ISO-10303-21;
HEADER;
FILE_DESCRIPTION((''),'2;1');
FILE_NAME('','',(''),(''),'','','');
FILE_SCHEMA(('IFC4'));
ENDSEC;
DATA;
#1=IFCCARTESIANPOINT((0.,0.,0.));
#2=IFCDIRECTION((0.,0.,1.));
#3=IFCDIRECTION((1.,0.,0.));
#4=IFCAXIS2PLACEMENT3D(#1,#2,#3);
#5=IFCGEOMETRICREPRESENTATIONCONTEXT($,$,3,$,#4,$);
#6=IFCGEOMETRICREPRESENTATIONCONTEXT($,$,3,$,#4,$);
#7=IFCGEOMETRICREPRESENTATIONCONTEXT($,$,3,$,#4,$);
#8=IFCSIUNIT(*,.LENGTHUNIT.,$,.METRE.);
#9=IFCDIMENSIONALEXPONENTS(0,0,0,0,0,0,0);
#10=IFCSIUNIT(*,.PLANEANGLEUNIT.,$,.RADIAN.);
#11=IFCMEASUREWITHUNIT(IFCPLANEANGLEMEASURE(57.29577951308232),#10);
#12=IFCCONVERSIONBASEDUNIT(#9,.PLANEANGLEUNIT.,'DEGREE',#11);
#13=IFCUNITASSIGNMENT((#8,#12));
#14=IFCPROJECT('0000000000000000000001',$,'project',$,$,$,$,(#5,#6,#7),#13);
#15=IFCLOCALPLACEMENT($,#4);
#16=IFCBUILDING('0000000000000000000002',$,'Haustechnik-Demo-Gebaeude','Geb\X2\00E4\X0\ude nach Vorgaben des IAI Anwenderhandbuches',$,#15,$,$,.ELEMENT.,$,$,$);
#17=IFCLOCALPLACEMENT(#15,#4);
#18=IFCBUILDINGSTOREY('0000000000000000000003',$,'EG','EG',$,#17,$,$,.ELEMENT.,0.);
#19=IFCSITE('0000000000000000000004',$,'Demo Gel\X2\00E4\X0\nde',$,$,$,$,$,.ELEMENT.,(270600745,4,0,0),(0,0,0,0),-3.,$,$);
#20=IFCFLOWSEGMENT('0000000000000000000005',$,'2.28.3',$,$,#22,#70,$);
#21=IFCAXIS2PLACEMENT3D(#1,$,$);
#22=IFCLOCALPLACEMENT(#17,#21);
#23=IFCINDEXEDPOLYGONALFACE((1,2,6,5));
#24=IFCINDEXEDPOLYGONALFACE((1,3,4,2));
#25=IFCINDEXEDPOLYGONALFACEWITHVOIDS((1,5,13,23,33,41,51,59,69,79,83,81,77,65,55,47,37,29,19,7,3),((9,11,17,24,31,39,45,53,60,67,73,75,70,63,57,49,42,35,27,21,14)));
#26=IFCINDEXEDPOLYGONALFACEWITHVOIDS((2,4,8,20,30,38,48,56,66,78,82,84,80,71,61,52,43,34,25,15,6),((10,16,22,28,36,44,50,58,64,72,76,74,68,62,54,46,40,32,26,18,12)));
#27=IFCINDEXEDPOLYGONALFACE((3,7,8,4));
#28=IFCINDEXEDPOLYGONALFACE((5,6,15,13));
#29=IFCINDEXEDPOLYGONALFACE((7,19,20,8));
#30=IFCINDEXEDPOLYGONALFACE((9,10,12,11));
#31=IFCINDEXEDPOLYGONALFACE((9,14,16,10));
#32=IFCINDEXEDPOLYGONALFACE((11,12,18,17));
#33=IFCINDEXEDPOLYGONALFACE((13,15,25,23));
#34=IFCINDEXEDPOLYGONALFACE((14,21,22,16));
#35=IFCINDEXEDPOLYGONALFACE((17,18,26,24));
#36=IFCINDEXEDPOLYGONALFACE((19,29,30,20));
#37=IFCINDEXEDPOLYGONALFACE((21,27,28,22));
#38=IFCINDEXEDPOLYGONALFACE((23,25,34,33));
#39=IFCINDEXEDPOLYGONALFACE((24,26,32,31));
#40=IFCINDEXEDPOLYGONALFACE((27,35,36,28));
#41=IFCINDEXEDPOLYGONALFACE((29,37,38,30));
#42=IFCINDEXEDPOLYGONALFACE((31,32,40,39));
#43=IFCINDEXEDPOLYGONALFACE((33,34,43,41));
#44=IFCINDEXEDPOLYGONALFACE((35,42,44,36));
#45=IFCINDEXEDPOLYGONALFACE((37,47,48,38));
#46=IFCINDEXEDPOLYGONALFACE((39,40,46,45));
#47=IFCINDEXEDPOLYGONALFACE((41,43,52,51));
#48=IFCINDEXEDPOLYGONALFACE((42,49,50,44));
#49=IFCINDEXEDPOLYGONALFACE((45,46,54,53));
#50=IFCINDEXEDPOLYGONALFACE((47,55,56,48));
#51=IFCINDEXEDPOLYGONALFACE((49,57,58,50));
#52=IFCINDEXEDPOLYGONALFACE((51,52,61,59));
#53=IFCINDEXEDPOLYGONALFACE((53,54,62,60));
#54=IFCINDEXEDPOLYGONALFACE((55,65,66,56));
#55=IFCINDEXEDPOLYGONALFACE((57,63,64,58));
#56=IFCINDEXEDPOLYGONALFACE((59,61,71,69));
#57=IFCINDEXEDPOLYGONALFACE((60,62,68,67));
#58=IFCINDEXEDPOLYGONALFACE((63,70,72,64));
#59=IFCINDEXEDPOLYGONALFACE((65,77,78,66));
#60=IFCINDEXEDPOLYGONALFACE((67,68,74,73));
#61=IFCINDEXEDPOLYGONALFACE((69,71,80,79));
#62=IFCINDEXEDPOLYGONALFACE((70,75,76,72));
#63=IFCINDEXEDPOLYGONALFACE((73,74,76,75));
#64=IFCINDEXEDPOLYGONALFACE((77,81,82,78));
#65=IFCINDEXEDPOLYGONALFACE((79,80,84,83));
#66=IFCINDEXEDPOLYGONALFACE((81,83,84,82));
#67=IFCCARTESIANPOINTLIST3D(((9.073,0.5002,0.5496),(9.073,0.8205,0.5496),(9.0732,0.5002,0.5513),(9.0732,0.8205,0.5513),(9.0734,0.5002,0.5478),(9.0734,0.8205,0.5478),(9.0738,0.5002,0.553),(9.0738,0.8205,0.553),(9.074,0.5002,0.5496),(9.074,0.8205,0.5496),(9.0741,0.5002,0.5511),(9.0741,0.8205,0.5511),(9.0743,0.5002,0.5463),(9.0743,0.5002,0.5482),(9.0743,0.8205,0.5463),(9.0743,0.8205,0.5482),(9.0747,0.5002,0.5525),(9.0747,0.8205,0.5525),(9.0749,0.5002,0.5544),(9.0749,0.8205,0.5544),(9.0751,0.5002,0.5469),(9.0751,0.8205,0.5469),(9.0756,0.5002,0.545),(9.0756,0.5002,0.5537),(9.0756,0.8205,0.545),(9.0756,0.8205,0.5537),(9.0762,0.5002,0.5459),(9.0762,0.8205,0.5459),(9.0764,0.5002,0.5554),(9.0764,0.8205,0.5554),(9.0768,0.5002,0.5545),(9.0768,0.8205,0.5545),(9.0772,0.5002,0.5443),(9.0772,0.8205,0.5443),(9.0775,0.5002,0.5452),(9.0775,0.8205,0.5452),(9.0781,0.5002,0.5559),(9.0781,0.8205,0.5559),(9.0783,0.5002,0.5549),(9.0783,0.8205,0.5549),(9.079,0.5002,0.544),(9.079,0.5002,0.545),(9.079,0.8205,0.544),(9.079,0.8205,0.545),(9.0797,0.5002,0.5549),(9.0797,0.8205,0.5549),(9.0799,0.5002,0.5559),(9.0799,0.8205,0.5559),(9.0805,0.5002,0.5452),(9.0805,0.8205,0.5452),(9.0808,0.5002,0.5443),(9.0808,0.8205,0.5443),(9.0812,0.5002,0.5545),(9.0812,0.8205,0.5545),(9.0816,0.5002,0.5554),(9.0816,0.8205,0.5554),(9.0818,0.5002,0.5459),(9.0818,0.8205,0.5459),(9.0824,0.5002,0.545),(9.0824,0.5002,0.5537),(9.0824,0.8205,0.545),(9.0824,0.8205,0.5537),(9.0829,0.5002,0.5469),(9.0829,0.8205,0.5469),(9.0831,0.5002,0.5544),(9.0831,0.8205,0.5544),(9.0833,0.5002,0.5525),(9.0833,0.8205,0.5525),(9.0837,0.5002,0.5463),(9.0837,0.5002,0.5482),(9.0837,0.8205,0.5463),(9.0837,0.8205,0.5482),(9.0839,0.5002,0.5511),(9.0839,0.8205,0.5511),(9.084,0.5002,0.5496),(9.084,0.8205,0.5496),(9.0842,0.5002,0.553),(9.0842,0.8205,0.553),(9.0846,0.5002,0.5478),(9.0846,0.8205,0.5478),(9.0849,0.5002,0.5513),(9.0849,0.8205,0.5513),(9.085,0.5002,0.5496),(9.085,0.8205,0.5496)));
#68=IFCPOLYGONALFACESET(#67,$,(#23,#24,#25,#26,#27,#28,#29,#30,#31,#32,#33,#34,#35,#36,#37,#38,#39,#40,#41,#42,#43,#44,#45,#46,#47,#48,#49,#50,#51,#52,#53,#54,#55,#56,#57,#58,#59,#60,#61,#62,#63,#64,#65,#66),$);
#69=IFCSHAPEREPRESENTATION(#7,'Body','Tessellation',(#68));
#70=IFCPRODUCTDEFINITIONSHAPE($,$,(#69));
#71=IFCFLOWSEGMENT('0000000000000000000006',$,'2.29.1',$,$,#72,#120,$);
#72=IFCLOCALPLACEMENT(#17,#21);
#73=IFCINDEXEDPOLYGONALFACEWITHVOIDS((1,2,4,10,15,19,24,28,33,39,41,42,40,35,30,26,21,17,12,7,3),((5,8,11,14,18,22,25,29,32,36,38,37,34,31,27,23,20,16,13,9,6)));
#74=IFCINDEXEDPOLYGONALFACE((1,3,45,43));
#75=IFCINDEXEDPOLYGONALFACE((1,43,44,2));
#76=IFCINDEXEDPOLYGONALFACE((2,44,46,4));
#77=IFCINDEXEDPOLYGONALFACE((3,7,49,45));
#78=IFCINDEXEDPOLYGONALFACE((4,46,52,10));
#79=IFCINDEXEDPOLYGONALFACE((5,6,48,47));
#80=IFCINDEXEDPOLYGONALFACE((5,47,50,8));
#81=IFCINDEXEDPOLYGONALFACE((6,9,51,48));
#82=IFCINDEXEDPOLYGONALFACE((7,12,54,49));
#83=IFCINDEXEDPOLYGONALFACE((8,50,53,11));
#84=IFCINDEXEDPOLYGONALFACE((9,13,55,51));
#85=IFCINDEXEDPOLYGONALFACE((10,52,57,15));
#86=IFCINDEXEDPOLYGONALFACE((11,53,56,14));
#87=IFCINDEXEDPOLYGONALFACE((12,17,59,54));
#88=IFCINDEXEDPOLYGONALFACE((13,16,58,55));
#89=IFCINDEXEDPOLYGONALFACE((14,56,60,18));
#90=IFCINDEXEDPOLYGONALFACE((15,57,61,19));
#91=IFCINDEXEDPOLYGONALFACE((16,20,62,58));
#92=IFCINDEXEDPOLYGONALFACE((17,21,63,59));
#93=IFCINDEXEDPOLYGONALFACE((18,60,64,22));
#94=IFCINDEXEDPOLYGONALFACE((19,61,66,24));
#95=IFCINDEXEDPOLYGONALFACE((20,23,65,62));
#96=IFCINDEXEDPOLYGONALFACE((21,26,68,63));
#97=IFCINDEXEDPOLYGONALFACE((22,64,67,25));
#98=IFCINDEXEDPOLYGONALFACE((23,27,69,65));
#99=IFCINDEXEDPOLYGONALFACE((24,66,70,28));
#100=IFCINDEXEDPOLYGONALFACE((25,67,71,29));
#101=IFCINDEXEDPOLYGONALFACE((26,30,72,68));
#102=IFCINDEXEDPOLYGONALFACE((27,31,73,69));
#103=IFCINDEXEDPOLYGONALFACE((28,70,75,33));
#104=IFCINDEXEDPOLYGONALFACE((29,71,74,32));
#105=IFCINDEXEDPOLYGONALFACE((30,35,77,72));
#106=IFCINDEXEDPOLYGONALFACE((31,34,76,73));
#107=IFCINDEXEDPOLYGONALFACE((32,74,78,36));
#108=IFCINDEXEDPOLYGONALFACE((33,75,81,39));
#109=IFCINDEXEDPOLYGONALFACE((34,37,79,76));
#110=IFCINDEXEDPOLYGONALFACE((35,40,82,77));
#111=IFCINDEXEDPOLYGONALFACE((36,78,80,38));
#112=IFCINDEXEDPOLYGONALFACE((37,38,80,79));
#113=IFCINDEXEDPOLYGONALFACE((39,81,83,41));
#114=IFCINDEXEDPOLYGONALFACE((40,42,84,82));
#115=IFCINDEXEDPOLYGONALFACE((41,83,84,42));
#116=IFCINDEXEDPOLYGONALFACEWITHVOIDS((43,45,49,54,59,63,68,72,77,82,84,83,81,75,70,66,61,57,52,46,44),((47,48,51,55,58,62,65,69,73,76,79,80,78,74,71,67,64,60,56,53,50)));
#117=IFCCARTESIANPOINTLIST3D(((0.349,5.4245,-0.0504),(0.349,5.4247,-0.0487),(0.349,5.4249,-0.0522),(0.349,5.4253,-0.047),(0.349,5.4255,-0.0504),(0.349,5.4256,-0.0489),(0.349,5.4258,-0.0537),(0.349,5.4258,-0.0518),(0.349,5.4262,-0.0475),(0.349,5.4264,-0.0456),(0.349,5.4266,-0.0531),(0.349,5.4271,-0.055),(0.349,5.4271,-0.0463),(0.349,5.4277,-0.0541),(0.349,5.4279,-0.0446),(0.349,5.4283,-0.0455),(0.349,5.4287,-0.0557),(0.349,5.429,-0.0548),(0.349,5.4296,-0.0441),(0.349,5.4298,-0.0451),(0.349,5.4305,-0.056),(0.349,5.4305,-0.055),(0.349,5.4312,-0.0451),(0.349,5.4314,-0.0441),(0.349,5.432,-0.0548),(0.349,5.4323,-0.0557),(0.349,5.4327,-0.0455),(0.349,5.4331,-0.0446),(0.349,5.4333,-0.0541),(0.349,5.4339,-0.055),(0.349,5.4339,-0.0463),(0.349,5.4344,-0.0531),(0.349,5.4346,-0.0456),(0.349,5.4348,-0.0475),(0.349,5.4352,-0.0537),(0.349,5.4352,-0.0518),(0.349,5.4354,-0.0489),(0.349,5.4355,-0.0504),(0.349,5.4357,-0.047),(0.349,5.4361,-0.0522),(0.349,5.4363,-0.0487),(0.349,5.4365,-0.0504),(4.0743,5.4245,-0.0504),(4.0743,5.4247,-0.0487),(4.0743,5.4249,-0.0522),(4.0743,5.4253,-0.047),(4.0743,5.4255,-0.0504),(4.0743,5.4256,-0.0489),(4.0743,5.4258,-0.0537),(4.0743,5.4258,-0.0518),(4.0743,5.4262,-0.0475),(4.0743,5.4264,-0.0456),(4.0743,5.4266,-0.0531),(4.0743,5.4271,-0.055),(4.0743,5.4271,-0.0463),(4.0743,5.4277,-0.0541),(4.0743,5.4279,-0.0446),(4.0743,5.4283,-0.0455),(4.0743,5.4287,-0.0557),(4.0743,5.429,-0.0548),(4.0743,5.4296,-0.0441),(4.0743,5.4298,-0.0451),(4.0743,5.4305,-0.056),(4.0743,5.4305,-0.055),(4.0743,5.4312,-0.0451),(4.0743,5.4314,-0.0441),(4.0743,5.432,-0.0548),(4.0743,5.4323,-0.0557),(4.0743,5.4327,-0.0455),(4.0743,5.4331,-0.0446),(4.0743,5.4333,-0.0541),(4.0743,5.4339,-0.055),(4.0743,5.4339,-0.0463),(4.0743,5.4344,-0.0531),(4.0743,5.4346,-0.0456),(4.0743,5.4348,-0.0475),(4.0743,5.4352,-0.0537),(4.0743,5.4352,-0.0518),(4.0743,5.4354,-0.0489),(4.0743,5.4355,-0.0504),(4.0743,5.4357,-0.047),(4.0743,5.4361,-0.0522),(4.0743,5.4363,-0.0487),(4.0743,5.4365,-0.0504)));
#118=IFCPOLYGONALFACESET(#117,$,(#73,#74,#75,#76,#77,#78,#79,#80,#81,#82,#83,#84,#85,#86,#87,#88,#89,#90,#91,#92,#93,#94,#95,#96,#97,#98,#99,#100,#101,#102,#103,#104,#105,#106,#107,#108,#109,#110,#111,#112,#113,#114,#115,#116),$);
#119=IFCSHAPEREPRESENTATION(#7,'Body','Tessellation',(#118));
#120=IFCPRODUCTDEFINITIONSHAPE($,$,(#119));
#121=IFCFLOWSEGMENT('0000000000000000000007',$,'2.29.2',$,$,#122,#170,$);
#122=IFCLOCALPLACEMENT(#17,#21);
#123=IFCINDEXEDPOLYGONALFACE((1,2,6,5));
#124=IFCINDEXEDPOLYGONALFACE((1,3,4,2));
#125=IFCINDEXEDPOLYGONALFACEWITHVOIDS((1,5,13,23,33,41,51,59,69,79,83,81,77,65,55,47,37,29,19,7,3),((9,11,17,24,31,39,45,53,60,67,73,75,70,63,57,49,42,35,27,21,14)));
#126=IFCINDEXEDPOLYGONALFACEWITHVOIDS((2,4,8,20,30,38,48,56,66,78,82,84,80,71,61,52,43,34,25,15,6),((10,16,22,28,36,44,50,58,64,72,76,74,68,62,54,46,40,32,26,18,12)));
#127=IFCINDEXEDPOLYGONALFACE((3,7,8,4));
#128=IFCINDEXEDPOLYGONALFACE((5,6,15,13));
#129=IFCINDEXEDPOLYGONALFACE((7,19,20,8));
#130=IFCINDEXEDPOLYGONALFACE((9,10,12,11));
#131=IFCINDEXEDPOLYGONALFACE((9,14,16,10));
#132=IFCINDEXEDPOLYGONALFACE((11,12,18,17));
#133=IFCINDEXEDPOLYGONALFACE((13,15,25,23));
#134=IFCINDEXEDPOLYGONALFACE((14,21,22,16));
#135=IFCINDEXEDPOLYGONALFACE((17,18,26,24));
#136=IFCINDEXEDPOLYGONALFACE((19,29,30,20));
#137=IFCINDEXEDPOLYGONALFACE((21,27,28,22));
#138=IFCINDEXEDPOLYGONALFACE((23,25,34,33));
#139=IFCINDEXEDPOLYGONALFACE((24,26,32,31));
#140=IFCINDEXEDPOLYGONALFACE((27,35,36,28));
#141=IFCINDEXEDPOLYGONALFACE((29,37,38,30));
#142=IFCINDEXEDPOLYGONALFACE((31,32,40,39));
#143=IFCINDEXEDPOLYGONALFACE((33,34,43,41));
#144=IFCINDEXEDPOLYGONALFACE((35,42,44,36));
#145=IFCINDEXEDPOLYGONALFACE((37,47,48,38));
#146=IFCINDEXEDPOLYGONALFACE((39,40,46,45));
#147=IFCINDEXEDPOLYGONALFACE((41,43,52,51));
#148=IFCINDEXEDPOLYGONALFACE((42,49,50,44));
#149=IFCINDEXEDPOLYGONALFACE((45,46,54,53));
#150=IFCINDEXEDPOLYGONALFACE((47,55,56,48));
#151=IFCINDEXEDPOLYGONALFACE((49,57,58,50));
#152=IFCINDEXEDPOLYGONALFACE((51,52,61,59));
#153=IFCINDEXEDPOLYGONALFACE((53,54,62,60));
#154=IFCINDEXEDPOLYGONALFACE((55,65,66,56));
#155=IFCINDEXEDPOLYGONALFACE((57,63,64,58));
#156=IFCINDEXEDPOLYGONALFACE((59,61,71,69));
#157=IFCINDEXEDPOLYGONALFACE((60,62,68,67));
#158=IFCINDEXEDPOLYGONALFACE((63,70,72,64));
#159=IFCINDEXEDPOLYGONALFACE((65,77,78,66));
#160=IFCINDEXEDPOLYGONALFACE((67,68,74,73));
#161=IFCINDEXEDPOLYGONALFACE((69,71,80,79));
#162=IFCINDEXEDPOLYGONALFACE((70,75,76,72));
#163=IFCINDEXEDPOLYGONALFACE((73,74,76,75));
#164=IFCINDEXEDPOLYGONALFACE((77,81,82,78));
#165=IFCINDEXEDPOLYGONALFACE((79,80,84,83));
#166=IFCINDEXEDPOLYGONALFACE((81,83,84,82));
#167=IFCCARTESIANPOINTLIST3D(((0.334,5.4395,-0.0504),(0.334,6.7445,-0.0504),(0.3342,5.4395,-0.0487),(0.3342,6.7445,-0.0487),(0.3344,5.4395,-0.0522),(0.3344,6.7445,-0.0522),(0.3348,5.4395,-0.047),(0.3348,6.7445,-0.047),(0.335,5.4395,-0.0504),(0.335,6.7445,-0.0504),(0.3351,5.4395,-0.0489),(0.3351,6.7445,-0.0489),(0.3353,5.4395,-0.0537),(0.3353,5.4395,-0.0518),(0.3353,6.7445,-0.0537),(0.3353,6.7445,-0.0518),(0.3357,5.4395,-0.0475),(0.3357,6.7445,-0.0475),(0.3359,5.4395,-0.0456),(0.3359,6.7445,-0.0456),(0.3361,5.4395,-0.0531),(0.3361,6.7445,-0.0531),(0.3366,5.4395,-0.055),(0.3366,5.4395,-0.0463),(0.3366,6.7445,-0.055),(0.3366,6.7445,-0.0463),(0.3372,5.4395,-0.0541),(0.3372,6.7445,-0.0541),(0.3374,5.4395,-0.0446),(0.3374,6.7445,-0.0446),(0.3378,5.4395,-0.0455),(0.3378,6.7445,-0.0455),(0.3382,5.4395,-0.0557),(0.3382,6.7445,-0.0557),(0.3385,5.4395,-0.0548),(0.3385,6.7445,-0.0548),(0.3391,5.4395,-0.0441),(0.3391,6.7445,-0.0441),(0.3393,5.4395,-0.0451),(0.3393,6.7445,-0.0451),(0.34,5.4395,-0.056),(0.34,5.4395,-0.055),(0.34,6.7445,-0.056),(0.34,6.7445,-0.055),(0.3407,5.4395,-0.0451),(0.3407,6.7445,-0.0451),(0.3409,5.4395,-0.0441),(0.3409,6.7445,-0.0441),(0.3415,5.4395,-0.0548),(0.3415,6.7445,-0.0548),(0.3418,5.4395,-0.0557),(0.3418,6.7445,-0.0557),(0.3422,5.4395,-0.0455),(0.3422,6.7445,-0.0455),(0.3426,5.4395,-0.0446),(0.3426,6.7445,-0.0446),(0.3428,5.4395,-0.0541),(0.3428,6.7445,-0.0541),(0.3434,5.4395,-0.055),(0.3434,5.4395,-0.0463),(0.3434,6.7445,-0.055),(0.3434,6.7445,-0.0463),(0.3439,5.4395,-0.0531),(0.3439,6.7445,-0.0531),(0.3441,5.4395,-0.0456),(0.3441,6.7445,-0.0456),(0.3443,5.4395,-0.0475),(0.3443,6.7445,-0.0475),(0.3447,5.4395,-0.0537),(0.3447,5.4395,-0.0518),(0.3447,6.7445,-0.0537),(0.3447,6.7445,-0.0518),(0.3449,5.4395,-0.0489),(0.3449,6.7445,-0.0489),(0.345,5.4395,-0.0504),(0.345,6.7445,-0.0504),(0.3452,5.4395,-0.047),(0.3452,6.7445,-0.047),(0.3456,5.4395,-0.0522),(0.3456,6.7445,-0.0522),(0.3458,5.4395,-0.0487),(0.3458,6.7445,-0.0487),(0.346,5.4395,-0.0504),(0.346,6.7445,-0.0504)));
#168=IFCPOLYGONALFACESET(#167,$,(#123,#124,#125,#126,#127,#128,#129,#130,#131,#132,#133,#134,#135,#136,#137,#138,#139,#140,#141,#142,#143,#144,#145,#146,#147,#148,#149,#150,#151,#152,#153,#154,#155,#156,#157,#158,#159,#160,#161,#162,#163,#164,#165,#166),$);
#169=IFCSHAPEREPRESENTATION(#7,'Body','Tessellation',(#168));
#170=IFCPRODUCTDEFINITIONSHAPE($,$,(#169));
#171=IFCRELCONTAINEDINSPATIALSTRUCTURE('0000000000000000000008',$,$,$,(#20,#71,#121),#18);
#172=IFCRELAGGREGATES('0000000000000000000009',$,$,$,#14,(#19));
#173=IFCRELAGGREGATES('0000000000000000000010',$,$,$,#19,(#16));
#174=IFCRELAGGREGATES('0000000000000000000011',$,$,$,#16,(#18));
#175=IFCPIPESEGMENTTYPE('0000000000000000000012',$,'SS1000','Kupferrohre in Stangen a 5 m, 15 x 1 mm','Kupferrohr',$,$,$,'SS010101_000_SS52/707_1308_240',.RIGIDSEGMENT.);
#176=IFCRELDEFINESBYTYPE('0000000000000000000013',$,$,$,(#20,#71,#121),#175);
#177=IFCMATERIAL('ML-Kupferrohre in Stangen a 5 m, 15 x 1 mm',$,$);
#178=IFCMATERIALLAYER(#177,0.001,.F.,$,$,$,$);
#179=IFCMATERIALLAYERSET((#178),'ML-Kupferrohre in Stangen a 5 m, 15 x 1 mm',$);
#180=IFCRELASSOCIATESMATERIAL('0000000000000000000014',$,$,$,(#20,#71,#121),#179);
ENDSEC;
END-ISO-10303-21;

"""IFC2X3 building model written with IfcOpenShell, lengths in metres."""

from ifc_helpers import new_model, entity, si_unit, converted_unit, frame, origin_with_axes, origin_2d_with_axis, place, context, project, spatial, hollow_circle, extrude, material, layer, layer_set, layer_usage, type_object, element, save


model = new_model("IFC2X3")

# Units and contexts
context_of_model_1 = context(None, 3, world=origin_with_axes())
context_of_model_2 = context(None, 3, world=origin_with_axes())
context_of_model_3 = context(None, 3, world=origin_with_axes())
ifc_project = project(units=[si_unit("LENGTHUNIT", "METRE"), converted_unit("PLANEANGLEUNIT", "DEGREE", entity("IfcPlaneAngleMeasure", 57.29577951308232), si_unit("PLANEANGLEUNIT", "RADIAN"), dimensions=[0, 0, 0, 0, 0, 0, 0])], contexts=[context_of_model_1, context_of_model_2, context_of_model_3])

# Site, building, storey
site = spatial("IfcSite", under=ifc_project, Name="Demo Gelände", CompositionType="ELEMENT", RefLatitude=(270600745, 4, 0, 0), RefLongitude=(0, 0, 0, 0), RefElevation=-3.0)
building_placement = place(None, origin_with_axes())
building = spatial("IfcBuilding", under=site, at=building_placement, Name="Haustechnik-Demo-Gebaeude", Description="Gebäude nach Vorgaben des IAI Anwenderhandbuches", CompositionType="ELEMENT")
storey_placement = place(building_placement, origin_with_axes())
storey = spatial("IfcBuildingStorey", under=building, at=storey_placement, Name="EG", Description="EG", CompositionType="ELEMENT", Elevation=0.0)

# Flow segments
ifc_material = material(Name="ML-Kupferrohre in Stangen a 5 m, 15 x 1 mm")
ifc_layer = layer(ifc_material, 0.001, ventilated=False)
ifc_layer_set = layer_set([ifc_layer], Name="ML-Kupferrohre in Stangen a 5 m, 15 x 1 mm")
ifc_layer_usage = layer_usage(ifc_layer_set, "AXIS2", "POSITIVE", 0.0)
pipe_segment_type_1 = type_object("IfcPipeSegmentType", Name="SS1000", Description="Kupferrohre in Stangen a 5 m, 15 x 1 mm", ApplicableOccurrence="Kupferrohr", ElementType="SS010101_000_SS52/707_1308_240", PredefinedType="RIGIDSEGMENT")
flow_segment_1_placement = place(storey_placement, frame((9.079, 0.5002, 0.55), z_axis=(0.0, 1.0, 0.0), x_axis=(0.0, 0.0, -1.0)))
element("IfcFlowSegment", 1, at=flow_segment_1_placement, inside=storey, type_object=pipe_segment_type_1, material=ifc_layer_usage, Name="2.28.3", context=context_of_model_3, shape_type="SweptSolid", body=[
    extrude(hollow_circle(Radius=0.006, WallThickness=0.001, at=origin_2d_with_axis()), origin_with_axes(), (0.0, 0.0, 1.0), 0.3203),
])
flow_segment_2_placement = place(storey_placement, frame((4.0743, 5.4305, -0.05), z_axis=(-1.0, 0.0, 0.0), x_axis=(0.0, 0.0, -1.0)))
element("IfcFlowSegment", 2, at=flow_segment_2_placement, inside=storey, type_object=pipe_segment_type_1, material=ifc_layer_usage, Name="2.29.1", context=context_of_model_3, shape_type="SweptSolid", body=[
    extrude(hollow_circle(Radius=0.006, WallThickness=0.001, at=origin_2d_with_axis()), origin_with_axes(), (0.0, 0.0, 1.0), 3.7253),
])
flow_segment_3_placement = place(storey_placement, frame((0.34, 5.4395, -0.05), z_axis=(0.0, 1.0, 0.0), x_axis=(0.0, 0.0, -1.0)))
element("IfcFlowSegment", 3, at=flow_segment_3_placement, inside=storey, type_object=pipe_segment_type_1, material=ifc_layer_usage, Name="2.29.2", context=context_of_model_3, shape_type="SweptSolid", body=[
    extrude(hollow_circle(Radius=0.006, WallThickness=0.001, at=origin_2d_with_axis()), origin_with_axes(), (0.0, 0.0, 1.0), 1.305),
])

save(model, "model.ifc")
